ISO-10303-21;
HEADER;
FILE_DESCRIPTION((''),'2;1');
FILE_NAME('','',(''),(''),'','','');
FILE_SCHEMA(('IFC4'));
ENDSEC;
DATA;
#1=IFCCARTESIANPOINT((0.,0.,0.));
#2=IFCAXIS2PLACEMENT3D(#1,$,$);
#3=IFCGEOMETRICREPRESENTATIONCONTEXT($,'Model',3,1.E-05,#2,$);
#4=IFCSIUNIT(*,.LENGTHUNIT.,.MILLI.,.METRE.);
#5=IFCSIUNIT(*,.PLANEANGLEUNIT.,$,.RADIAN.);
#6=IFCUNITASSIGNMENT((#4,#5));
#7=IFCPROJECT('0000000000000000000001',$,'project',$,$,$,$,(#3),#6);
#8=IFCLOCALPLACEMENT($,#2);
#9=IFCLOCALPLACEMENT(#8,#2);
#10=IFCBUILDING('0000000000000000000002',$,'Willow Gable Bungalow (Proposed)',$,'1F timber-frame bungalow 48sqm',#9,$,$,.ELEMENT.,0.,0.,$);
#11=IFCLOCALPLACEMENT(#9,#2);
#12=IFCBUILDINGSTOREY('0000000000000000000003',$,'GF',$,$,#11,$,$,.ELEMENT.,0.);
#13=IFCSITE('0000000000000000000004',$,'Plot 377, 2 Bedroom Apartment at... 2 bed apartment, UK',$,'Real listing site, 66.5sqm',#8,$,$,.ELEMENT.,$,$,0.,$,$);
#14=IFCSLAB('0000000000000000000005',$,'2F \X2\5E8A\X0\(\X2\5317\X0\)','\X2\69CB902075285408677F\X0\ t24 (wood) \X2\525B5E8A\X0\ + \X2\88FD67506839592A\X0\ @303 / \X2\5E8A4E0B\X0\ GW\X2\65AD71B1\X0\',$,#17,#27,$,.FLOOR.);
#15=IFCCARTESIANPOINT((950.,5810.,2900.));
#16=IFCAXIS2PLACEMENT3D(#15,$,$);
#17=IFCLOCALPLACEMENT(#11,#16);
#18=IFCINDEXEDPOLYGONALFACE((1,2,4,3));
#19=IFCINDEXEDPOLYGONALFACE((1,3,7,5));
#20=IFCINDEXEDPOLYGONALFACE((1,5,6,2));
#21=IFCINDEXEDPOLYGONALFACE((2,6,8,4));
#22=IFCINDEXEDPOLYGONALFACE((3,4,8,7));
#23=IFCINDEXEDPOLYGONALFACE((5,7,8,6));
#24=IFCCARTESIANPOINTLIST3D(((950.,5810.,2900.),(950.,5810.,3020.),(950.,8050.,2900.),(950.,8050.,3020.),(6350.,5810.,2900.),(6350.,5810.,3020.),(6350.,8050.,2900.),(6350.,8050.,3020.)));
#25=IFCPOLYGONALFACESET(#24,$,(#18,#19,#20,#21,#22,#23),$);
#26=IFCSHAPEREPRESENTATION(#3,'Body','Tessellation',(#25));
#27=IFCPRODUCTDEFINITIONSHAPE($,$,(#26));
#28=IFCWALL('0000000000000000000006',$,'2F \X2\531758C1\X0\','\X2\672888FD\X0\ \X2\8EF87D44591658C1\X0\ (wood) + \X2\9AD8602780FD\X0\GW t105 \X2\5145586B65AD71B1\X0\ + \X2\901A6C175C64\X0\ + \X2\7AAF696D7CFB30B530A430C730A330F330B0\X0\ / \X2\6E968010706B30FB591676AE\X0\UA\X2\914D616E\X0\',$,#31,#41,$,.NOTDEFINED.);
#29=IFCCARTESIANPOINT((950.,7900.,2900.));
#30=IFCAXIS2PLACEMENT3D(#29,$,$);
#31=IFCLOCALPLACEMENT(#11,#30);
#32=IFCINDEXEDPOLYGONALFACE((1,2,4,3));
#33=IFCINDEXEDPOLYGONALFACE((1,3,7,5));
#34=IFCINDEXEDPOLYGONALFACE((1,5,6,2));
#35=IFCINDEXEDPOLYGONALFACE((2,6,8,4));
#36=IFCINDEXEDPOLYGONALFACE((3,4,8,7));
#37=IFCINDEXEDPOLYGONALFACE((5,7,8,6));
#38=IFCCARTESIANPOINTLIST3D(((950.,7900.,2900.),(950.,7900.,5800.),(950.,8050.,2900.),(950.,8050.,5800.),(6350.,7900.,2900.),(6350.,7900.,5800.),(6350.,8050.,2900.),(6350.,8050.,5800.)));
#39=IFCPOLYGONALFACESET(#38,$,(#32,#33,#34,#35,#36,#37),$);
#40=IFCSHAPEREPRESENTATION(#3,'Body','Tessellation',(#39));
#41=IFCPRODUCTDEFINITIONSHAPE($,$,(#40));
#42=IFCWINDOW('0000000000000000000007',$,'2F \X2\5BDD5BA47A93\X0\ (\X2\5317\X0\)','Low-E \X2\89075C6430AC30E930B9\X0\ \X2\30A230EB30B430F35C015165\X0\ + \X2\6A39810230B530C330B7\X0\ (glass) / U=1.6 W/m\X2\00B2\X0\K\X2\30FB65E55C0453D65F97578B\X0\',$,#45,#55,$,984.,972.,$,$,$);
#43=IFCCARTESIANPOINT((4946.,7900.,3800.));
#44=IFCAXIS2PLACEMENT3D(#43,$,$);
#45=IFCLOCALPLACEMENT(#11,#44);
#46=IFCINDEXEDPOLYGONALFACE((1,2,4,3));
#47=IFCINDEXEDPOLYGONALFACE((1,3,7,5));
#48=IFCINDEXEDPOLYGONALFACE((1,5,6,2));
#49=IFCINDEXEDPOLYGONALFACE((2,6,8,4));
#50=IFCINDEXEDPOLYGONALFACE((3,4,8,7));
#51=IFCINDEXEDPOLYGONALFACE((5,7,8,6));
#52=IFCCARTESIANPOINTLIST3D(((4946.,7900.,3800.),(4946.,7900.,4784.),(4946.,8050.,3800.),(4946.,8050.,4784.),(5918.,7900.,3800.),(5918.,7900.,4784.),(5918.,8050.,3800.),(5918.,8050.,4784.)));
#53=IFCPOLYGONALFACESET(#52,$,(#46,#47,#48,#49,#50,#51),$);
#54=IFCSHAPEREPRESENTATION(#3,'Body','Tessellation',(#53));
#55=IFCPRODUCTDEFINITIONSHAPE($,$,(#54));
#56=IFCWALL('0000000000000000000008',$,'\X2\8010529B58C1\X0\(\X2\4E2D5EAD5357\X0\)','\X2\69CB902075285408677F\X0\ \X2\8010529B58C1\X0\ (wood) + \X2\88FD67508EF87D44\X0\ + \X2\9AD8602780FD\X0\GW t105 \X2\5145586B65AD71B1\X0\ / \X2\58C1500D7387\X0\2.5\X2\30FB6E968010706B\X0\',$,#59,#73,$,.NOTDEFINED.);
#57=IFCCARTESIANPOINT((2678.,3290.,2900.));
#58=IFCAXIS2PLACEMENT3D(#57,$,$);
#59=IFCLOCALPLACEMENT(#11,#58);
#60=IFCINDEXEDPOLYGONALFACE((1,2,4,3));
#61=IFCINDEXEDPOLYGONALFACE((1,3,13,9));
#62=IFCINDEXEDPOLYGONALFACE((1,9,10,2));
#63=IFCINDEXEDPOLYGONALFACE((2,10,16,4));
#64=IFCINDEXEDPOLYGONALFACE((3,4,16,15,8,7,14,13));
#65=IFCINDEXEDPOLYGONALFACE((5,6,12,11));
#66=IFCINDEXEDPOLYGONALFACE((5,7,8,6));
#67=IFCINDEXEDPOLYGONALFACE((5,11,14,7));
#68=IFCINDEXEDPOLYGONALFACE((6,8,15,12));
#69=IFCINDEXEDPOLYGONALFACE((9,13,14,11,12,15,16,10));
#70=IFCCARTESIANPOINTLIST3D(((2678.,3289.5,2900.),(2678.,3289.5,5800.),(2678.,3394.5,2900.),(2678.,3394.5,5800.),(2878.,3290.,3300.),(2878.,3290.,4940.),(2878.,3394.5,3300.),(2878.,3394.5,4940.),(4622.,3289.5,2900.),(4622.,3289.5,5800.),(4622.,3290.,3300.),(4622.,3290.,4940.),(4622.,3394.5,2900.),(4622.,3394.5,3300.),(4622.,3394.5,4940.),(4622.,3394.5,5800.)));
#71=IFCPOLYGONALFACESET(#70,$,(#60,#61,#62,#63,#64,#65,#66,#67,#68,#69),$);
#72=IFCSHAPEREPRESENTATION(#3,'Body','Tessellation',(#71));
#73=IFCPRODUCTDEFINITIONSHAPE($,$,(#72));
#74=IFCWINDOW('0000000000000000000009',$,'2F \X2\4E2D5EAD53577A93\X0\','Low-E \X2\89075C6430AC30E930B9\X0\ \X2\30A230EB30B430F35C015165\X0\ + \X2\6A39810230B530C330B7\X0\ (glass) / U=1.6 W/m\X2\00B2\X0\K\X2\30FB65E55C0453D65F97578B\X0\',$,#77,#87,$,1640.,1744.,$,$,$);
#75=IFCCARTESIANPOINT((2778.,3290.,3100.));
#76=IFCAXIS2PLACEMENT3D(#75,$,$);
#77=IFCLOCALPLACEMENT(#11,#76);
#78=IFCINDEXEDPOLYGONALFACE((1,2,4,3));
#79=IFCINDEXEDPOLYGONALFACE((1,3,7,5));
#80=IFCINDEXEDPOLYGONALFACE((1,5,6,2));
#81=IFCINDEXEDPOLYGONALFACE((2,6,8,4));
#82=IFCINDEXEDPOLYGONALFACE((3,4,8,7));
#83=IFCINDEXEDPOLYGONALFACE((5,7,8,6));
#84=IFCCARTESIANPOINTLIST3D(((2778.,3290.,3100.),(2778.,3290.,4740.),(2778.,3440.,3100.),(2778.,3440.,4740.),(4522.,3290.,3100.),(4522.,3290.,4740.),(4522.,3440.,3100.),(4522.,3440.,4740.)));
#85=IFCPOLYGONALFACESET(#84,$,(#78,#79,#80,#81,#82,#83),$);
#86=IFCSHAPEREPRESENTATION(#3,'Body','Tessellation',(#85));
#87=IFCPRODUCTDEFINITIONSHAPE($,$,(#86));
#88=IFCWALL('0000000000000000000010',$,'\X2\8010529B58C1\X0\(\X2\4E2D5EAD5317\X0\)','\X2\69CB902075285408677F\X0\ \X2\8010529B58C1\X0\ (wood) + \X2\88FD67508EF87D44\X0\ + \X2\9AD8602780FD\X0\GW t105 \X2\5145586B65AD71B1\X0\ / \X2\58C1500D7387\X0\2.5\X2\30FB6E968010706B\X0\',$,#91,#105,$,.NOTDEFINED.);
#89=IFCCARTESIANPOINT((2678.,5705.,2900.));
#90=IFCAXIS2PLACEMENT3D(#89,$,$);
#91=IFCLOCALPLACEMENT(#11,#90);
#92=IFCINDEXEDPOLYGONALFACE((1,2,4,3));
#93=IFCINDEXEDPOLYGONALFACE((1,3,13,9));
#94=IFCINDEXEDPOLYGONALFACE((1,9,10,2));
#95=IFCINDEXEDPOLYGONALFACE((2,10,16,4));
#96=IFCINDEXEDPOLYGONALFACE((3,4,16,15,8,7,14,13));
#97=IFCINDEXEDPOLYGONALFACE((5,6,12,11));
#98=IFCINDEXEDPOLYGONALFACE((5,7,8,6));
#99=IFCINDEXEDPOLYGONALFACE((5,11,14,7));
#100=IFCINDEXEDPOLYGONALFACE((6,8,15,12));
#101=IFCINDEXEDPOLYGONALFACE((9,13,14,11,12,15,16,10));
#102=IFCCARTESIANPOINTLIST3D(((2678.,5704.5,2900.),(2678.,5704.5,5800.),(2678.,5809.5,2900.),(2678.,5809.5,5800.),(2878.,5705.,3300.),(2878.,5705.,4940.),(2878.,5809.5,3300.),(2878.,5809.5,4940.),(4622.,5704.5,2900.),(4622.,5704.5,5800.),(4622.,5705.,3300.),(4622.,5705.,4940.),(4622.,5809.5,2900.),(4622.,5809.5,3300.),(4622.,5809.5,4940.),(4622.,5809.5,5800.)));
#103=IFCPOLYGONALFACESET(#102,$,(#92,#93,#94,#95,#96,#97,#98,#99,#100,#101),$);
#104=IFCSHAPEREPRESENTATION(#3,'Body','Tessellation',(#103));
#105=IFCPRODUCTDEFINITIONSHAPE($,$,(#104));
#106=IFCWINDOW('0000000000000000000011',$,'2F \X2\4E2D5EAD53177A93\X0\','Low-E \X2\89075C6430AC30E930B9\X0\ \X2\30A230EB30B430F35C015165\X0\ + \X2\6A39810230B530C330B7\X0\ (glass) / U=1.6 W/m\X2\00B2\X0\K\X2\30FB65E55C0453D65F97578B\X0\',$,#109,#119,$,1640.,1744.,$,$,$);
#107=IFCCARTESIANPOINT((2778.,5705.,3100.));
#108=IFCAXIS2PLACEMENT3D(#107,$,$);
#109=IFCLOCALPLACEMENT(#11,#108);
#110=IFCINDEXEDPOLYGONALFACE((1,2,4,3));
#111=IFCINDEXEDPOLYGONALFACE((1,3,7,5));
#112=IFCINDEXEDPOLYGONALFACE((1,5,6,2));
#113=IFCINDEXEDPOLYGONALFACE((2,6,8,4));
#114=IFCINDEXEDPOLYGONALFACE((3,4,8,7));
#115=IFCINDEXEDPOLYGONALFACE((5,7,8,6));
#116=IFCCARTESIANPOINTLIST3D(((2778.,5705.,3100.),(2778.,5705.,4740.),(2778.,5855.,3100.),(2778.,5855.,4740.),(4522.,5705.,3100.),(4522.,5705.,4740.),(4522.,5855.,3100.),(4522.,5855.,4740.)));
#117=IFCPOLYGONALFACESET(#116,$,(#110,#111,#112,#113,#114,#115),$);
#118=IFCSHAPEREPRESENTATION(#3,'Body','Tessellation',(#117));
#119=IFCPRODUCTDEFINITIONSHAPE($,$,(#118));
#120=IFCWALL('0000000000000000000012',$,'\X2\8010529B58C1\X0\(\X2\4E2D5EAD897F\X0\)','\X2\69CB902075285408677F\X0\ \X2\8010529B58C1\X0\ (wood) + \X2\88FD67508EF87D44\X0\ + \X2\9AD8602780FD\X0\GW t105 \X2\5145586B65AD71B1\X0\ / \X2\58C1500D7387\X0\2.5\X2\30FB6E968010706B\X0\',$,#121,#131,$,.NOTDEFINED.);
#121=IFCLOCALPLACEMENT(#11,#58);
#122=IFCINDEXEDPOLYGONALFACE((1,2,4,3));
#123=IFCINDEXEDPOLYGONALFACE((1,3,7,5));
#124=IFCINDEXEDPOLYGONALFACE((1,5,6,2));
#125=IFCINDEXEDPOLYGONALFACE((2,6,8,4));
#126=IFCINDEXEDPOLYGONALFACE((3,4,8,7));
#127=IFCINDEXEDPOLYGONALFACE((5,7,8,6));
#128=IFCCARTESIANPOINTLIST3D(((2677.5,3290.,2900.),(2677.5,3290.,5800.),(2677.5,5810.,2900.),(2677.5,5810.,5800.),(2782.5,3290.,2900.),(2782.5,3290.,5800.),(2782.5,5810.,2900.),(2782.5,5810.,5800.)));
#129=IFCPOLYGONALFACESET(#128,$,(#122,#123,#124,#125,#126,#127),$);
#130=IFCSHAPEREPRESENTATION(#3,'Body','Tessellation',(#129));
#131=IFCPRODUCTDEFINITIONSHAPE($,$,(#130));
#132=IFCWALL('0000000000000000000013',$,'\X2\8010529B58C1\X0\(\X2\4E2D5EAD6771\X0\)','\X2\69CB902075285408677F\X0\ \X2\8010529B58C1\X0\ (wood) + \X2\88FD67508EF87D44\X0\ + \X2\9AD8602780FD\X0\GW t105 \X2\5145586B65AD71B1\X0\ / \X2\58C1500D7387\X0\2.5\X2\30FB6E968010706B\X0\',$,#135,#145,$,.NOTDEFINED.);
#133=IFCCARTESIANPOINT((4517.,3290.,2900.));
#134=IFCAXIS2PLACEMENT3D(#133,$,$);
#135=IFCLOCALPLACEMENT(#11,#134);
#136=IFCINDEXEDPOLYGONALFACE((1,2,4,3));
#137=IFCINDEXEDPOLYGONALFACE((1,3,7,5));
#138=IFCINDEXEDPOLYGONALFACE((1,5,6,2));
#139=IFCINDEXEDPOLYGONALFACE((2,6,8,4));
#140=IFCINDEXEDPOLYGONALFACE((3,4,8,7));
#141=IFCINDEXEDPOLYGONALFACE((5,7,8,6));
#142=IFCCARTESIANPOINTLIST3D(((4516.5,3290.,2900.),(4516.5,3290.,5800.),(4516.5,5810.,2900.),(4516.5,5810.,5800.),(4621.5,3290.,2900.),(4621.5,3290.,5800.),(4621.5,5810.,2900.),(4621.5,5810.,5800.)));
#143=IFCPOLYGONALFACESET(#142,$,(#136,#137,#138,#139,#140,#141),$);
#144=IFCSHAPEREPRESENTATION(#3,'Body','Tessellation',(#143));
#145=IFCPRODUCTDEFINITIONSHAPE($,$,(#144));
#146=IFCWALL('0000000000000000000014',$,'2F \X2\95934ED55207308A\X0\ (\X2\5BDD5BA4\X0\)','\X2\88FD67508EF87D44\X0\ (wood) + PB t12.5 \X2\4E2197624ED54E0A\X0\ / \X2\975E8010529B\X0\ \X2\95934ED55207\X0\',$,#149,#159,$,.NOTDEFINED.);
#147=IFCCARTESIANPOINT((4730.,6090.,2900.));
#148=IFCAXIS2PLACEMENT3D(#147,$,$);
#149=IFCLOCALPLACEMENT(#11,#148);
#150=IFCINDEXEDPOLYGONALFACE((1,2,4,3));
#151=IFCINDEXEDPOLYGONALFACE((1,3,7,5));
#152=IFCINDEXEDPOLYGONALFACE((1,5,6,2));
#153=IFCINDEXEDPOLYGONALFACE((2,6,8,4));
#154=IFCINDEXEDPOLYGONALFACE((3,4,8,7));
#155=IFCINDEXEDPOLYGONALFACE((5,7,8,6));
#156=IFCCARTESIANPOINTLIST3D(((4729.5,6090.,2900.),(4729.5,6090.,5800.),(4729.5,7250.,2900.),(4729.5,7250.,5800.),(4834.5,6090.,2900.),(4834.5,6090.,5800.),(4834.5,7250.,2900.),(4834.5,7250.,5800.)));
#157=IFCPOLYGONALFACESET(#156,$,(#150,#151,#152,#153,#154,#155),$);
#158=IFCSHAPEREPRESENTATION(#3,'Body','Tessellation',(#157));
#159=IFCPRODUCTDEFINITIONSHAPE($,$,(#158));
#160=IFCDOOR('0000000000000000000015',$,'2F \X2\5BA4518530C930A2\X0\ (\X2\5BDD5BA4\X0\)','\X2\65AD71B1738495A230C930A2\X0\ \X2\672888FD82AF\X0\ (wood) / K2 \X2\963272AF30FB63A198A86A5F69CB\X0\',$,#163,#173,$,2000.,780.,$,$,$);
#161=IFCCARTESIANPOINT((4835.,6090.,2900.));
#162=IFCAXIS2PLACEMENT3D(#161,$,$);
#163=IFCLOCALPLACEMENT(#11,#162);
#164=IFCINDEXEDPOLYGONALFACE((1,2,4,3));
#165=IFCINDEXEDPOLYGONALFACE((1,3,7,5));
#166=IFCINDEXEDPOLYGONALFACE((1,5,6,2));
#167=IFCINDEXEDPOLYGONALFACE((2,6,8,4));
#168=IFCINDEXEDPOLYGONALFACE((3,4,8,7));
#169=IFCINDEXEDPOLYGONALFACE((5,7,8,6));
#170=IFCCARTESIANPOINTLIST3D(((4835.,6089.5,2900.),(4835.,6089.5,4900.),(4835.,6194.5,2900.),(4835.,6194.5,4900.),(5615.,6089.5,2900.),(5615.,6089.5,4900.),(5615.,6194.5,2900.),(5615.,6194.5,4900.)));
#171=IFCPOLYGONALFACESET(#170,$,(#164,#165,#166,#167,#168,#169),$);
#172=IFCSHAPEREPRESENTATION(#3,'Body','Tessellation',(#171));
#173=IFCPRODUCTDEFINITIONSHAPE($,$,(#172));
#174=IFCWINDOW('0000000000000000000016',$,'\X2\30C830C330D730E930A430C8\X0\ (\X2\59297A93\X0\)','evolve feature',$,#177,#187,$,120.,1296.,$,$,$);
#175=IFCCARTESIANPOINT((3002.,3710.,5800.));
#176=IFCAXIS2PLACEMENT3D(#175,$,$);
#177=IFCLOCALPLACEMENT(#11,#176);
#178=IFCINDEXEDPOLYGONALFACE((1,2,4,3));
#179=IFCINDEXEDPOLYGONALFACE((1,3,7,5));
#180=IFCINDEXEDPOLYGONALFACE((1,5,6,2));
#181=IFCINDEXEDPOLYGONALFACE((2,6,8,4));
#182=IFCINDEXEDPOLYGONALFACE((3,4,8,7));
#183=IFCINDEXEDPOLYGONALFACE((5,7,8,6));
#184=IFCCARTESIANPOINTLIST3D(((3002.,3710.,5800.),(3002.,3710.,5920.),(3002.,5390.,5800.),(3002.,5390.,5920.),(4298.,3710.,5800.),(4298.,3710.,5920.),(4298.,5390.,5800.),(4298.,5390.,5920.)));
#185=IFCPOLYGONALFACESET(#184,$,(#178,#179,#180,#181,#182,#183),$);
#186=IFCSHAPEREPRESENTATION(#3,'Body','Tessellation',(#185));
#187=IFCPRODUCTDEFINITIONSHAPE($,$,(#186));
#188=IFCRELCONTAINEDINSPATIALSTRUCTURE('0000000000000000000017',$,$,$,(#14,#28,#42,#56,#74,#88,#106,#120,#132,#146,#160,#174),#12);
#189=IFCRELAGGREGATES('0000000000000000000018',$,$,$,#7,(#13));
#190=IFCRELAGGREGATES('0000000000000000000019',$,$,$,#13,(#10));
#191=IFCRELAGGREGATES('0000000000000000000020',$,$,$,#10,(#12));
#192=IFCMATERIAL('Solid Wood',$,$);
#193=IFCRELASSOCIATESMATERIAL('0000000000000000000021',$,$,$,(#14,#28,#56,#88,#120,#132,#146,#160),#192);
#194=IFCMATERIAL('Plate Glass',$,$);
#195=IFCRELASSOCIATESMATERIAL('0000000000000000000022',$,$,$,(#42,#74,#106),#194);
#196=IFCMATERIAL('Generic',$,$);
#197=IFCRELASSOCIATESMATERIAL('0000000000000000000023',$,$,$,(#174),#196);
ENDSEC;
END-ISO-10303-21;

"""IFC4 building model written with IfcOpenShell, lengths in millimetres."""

from ifc_helpers import new_model, si_unit, frame, frame_2d, origin, place, context, project, spatial, rectangle, extrude, material, element, fill, save


model = new_model("IFC4")

# Units and contexts
model_context = context("Model", 3, precision=1e-05, world=origin())
ifc_project = project(units=[si_unit("LENGTHUNIT", "METRE", prefix="MILLI"), si_unit("PLANEANGLEUNIT", "RADIAN")], contexts=[model_context])

# Site, building, storey
site_placement = place(None, origin())
site = spatial("IfcSite", under=ifc_project, at=site_placement, Name="Plot 377, 2 Bedroom Apartment at... 2 bed apartment, UK", ObjectType="Real listing site, 66.5sqm", CompositionType="ELEMENT", RefElevation=0.0)
building_placement = place(site_placement, origin())
building = spatial("IfcBuilding", under=site, at=building_placement, Name="Willow Gable Bungalow (Proposed)", ObjectType="1F timber-frame bungalow 48sqm", CompositionType="ELEMENT", ElevationOfRefHeight=0.0, ElevationOfTerrain=0.0)
storey_placement = place(building_placement, origin())
storey = spatial("IfcBuildingStorey", under=building, at=storey_placement, Name="GF", CompositionType="ELEMENT", Elevation=0.0)

# Slab
ifc_material_1 = material(Name="Solid Wood")
slab_placement = place(storey_placement, frame((950.0, 5810.0, 2900.0)))
element("IfcSlab", 1, at=slab_placement, inside=storey, material=ifc_material_1, Name="2F 床(北)", Description="構造用合板 t24 (wood) 剛床 + 製材根太 @303 / 床下 GW断熱", PredefinedType="FLOOR", context=model_context, shape_type="SweptSolid", body=[
    extrude(rectangle(XDim=5400.0, YDim=2240.0, at=frame_2d((2700.0, 1120.0))), frame((950.0, 5810.0, 2900.0)), (0.0, 0.0, 1.0), 120.0),
])

# Walls, openings, windows
wall_1_placement = place(storey_placement, frame((950.0, 7900.0, 2900.0)))
wall_1 = element("IfcWall", 2, at=wall_1_placement, inside=storey, material=ifc_material_1, Name="2F 北壁", Description="木製 軸組外壁 (wood) + 高性能GW t105 充填断熱 + 通気層 + 窯業系サイディング / 準耐火・外皮UA配慮", PredefinedType="NOTDEFINED", context=model_context, shape_type="SweptSolid", body=[
    extrude(rectangle(XDim=5400.0, YDim=150.0, at=frame_2d((2700.0, 75.0))), frame((950.0, 7900.0, 2900.0)), (0.0, 0.0, 1.0), 2900.0),
])
opening_1_placement = place(storey_placement, frame((4946.0, 7900.0, 3800.0)))
opening_1 = element("IfcOpeningElement", 3, at=opening_1_placement, cuts=wall_1, PredefinedType="NOTDEFINED", context=model_context, shape_type="SweptSolid", body=[
    extrude(rectangle(XDim=972.0, YDim=150.0, at=frame_2d((486.0, 75.0))), frame((4946.0, 7900.0, 3800.0)), (0.0, 0.0, 1.0), 984.0),
])
ifc_material_2 = material(Name="Plate Glass")
window_1_placement = place(storey_placement, frame((4946.0, 7900.0, 3800.0)))
window_1 = element("IfcWindow", 4, at=window_1_placement, inside=storey, material=ifc_material_2, Name="2F 寝室窓 (北)", Description="Low-E 複層ガラス アルゴン封入 + 樹脂サッシ (glass) / U=1.6 W/m²K・日射取得型", OverallHeight=984.0, OverallWidth=972.0, context=model_context, shape_type="SweptSolid", body=[
    extrude(rectangle(XDim=972.0, YDim=150.0, at=frame_2d((486.0, 75.0))), frame((4946.0, 7900.0, 3800.0)), (0.0, 0.0, 1.0), 984.0),
])
fill(opening_1, window_1)
wall_2_placement = place(storey_placement, frame((2678.0, 3290.0, 2900.0)))
wall_2 = element("IfcWall", 5, at=wall_2_placement, inside=storey, material=ifc_material_1, Name="耐力壁(中庭南)", Description="構造用合板 耐力壁 (wood) + 製材軸組 + 高性能GW t105 充填断熱 / 壁倍率2.5・準耐火", PredefinedType="NOTDEFINED", context=model_context, shape_type="SweptSolid", body=[
    extrude(rectangle(XDim=1944.0, YDim=105.0, at=frame_2d((972.0, 52.0))), frame((2678.0, 3290.0, 2900.0)), (0.0, 0.0, 1.0), 2900.0),
])
opening_2_placement = place(storey_placement, frame((2778.0, 3290.0, 3100.0)))
opening_2 = element("IfcOpeningElement", 6, at=opening_2_placement, cuts=wall_2, PredefinedType="NOTDEFINED", context=model_context, shape_type="SweptSolid", body=[
    extrude(rectangle(XDim=1744.0, YDim=150.0, at=frame_2d((872.0, 75.0))), frame((2778.0, 3290.0, 3100.0)), (0.0, 0.0, 1.0), 1640.0),
])
window_2_placement = place(storey_placement, frame((2778.0, 3290.0, 3100.0)))
window_2 = element("IfcWindow", 7, at=window_2_placement, inside=storey, material=ifc_material_2, Name="2F 中庭南窓", Description="Low-E 複層ガラス アルゴン封入 + 樹脂サッシ (glass) / U=1.6 W/m²K・日射取得型", OverallHeight=1640.0, OverallWidth=1744.0, context=model_context, shape_type="SweptSolid", body=[
    extrude(rectangle(XDim=1744.0, YDim=150.0, at=frame_2d((872.0, 75.0))), frame((2778.0, 3290.0, 3100.0)), (0.0, 0.0, 1.0), 1640.0),
])
fill(opening_2, window_2)
wall_3_placement = place(storey_placement, frame((2678.0, 5705.0, 2900.0)))
wall_3 = element("IfcWall", 8, at=wall_3_placement, inside=storey, material=ifc_material_1, Name="耐力壁(中庭北)", Description="構造用合板 耐力壁 (wood) + 製材軸組 + 高性能GW t105 充填断熱 / 壁倍率2.5・準耐火", PredefinedType="NOTDEFINED", context=model_context, shape_type="SweptSolid", body=[
    extrude(rectangle(XDim=1944.0, YDim=105.0, at=frame_2d((972.0, 52.0))), frame((2678.0, 5705.0, 2900.0)), (0.0, 0.0, 1.0), 2900.0),
])
opening_3_placement = place(storey_placement, frame((2778.0, 5705.0, 3100.0)))
opening_3 = element("IfcOpeningElement", 9, at=opening_3_placement, cuts=wall_3, PredefinedType="NOTDEFINED", context=model_context, shape_type="SweptSolid", body=[
    extrude(rectangle(XDim=1744.0, YDim=150.0, at=frame_2d((872.0, 75.0))), frame((2778.0, 5705.0, 3100.0)), (0.0, 0.0, 1.0), 1640.0),
])
window_3_placement = place(storey_placement, frame((2778.0, 5705.0, 3100.0)))
window_3 = element("IfcWindow", 10, at=window_3_placement, inside=storey, material=ifc_material_2, Name="2F 中庭北窓", Description="Low-E 複層ガラス アルゴン封入 + 樹脂サッシ (glass) / U=1.6 W/m²K・日射取得型", OverallHeight=1640.0, OverallWidth=1744.0, context=model_context, shape_type="SweptSolid", body=[
    extrude(rectangle(XDim=1744.0, YDim=150.0, at=frame_2d((872.0, 75.0))), frame((2778.0, 5705.0, 3100.0)), (0.0, 0.0, 1.0), 1640.0),
])
fill(opening_3, window_3)

# Walls
wall_4_placement = place(storey_placement, frame((2678.0, 3290.0, 2900.0)))
element("IfcWall", 11, at=wall_4_placement, inside=storey, material=ifc_material_1, Name="耐力壁(中庭西)", Description="構造用合板 耐力壁 (wood) + 製材軸組 + 高性能GW t105 充填断熱 / 壁倍率2.5・準耐火", PredefinedType="NOTDEFINED", context=model_context, shape_type="SweptSolid", body=[
    extrude(rectangle(XDim=105.0, YDim=2520.0, at=frame_2d((52.0, 1260.0))), frame((2678.0, 3290.0, 2900.0)), (0.0, 0.0, 1.0), 2900.0),
])
wall_5_placement = place(storey_placement, frame((4517.0, 3290.0, 2900.0)))
element("IfcWall", 12, at=wall_5_placement, inside=storey, material=ifc_material_1, Name="耐力壁(中庭東)", Description="構造用合板 耐力壁 (wood) + 製材軸組 + 高性能GW t105 充填断熱 / 壁倍率2.5・準耐火", PredefinedType="NOTDEFINED", context=model_context, shape_type="SweptSolid", body=[
    extrude(rectangle(XDim=105.0, YDim=2520.0, at=frame_2d((52.0, 1260.0))), frame((4517.0, 3290.0, 2900.0)), (0.0, 0.0, 1.0), 2900.0),
])
wall_6_placement = place(storey_placement, frame((4730.0, 6090.0, 2900.0)))
element("IfcWall", 13, at=wall_6_placement, inside=storey, material=ifc_material_1, Name="2F 間仕切り (寝室)", Description="製材軸組 (wood) + PB t12.5 両面仕上 / 非耐力 間仕切", PredefinedType="NOTDEFINED", context=model_context, shape_type="SweptSolid", body=[
    extrude(rectangle(XDim=105.0, YDim=1160.0, at=frame_2d((52.0, 580.0))), frame((4730.0, 6090.0, 2900.0)), (0.0, 0.0, 1.0), 2900.0),
])

# Door
door_placement = place(storey_placement, frame((4835.0, 6090.0, 2900.0)))
element("IfcDoor", 14, at=door_placement, inside=storey, material=ifc_material_1, Name="2F 室内ドア (寝室)", Description="断熱玄関ドア 木製芯 (wood) / K2 防犯・採風機構", OverallHeight=2000.0, OverallWidth=780.0, context=model_context, shape_type="SweptSolid", body=[
    extrude(rectangle(XDim=780.0, YDim=105.0, at=frame_2d((390.0, 52.0))), frame((4835.0, 6090.0, 2900.0)), (0.0, 0.0, 1.0), 2000.0),
])

# Window
ifc_material_3 = material(Name="Generic")
window_4_placement = place(storey_placement, frame((3002.0, 3710.0, 5800.0)))
element("IfcWindow", 15, at=window_4_placement, inside=storey, material=ifc_material_3, Name="トップライト (天窓)", Description="evolve feature", OverallHeight=120.0, OverallWidth=1296.0, context=model_context, shape_type="SweptSolid", body=[
    extrude(rectangle(XDim=1296.0, YDim=1680.0, at=frame_2d((648.0, 840.0))), frame((3002.0, 3710.0, 5800.0)), (0.0, 0.0, 1.0), 120.0),
])

save(model, "model.ifc")
